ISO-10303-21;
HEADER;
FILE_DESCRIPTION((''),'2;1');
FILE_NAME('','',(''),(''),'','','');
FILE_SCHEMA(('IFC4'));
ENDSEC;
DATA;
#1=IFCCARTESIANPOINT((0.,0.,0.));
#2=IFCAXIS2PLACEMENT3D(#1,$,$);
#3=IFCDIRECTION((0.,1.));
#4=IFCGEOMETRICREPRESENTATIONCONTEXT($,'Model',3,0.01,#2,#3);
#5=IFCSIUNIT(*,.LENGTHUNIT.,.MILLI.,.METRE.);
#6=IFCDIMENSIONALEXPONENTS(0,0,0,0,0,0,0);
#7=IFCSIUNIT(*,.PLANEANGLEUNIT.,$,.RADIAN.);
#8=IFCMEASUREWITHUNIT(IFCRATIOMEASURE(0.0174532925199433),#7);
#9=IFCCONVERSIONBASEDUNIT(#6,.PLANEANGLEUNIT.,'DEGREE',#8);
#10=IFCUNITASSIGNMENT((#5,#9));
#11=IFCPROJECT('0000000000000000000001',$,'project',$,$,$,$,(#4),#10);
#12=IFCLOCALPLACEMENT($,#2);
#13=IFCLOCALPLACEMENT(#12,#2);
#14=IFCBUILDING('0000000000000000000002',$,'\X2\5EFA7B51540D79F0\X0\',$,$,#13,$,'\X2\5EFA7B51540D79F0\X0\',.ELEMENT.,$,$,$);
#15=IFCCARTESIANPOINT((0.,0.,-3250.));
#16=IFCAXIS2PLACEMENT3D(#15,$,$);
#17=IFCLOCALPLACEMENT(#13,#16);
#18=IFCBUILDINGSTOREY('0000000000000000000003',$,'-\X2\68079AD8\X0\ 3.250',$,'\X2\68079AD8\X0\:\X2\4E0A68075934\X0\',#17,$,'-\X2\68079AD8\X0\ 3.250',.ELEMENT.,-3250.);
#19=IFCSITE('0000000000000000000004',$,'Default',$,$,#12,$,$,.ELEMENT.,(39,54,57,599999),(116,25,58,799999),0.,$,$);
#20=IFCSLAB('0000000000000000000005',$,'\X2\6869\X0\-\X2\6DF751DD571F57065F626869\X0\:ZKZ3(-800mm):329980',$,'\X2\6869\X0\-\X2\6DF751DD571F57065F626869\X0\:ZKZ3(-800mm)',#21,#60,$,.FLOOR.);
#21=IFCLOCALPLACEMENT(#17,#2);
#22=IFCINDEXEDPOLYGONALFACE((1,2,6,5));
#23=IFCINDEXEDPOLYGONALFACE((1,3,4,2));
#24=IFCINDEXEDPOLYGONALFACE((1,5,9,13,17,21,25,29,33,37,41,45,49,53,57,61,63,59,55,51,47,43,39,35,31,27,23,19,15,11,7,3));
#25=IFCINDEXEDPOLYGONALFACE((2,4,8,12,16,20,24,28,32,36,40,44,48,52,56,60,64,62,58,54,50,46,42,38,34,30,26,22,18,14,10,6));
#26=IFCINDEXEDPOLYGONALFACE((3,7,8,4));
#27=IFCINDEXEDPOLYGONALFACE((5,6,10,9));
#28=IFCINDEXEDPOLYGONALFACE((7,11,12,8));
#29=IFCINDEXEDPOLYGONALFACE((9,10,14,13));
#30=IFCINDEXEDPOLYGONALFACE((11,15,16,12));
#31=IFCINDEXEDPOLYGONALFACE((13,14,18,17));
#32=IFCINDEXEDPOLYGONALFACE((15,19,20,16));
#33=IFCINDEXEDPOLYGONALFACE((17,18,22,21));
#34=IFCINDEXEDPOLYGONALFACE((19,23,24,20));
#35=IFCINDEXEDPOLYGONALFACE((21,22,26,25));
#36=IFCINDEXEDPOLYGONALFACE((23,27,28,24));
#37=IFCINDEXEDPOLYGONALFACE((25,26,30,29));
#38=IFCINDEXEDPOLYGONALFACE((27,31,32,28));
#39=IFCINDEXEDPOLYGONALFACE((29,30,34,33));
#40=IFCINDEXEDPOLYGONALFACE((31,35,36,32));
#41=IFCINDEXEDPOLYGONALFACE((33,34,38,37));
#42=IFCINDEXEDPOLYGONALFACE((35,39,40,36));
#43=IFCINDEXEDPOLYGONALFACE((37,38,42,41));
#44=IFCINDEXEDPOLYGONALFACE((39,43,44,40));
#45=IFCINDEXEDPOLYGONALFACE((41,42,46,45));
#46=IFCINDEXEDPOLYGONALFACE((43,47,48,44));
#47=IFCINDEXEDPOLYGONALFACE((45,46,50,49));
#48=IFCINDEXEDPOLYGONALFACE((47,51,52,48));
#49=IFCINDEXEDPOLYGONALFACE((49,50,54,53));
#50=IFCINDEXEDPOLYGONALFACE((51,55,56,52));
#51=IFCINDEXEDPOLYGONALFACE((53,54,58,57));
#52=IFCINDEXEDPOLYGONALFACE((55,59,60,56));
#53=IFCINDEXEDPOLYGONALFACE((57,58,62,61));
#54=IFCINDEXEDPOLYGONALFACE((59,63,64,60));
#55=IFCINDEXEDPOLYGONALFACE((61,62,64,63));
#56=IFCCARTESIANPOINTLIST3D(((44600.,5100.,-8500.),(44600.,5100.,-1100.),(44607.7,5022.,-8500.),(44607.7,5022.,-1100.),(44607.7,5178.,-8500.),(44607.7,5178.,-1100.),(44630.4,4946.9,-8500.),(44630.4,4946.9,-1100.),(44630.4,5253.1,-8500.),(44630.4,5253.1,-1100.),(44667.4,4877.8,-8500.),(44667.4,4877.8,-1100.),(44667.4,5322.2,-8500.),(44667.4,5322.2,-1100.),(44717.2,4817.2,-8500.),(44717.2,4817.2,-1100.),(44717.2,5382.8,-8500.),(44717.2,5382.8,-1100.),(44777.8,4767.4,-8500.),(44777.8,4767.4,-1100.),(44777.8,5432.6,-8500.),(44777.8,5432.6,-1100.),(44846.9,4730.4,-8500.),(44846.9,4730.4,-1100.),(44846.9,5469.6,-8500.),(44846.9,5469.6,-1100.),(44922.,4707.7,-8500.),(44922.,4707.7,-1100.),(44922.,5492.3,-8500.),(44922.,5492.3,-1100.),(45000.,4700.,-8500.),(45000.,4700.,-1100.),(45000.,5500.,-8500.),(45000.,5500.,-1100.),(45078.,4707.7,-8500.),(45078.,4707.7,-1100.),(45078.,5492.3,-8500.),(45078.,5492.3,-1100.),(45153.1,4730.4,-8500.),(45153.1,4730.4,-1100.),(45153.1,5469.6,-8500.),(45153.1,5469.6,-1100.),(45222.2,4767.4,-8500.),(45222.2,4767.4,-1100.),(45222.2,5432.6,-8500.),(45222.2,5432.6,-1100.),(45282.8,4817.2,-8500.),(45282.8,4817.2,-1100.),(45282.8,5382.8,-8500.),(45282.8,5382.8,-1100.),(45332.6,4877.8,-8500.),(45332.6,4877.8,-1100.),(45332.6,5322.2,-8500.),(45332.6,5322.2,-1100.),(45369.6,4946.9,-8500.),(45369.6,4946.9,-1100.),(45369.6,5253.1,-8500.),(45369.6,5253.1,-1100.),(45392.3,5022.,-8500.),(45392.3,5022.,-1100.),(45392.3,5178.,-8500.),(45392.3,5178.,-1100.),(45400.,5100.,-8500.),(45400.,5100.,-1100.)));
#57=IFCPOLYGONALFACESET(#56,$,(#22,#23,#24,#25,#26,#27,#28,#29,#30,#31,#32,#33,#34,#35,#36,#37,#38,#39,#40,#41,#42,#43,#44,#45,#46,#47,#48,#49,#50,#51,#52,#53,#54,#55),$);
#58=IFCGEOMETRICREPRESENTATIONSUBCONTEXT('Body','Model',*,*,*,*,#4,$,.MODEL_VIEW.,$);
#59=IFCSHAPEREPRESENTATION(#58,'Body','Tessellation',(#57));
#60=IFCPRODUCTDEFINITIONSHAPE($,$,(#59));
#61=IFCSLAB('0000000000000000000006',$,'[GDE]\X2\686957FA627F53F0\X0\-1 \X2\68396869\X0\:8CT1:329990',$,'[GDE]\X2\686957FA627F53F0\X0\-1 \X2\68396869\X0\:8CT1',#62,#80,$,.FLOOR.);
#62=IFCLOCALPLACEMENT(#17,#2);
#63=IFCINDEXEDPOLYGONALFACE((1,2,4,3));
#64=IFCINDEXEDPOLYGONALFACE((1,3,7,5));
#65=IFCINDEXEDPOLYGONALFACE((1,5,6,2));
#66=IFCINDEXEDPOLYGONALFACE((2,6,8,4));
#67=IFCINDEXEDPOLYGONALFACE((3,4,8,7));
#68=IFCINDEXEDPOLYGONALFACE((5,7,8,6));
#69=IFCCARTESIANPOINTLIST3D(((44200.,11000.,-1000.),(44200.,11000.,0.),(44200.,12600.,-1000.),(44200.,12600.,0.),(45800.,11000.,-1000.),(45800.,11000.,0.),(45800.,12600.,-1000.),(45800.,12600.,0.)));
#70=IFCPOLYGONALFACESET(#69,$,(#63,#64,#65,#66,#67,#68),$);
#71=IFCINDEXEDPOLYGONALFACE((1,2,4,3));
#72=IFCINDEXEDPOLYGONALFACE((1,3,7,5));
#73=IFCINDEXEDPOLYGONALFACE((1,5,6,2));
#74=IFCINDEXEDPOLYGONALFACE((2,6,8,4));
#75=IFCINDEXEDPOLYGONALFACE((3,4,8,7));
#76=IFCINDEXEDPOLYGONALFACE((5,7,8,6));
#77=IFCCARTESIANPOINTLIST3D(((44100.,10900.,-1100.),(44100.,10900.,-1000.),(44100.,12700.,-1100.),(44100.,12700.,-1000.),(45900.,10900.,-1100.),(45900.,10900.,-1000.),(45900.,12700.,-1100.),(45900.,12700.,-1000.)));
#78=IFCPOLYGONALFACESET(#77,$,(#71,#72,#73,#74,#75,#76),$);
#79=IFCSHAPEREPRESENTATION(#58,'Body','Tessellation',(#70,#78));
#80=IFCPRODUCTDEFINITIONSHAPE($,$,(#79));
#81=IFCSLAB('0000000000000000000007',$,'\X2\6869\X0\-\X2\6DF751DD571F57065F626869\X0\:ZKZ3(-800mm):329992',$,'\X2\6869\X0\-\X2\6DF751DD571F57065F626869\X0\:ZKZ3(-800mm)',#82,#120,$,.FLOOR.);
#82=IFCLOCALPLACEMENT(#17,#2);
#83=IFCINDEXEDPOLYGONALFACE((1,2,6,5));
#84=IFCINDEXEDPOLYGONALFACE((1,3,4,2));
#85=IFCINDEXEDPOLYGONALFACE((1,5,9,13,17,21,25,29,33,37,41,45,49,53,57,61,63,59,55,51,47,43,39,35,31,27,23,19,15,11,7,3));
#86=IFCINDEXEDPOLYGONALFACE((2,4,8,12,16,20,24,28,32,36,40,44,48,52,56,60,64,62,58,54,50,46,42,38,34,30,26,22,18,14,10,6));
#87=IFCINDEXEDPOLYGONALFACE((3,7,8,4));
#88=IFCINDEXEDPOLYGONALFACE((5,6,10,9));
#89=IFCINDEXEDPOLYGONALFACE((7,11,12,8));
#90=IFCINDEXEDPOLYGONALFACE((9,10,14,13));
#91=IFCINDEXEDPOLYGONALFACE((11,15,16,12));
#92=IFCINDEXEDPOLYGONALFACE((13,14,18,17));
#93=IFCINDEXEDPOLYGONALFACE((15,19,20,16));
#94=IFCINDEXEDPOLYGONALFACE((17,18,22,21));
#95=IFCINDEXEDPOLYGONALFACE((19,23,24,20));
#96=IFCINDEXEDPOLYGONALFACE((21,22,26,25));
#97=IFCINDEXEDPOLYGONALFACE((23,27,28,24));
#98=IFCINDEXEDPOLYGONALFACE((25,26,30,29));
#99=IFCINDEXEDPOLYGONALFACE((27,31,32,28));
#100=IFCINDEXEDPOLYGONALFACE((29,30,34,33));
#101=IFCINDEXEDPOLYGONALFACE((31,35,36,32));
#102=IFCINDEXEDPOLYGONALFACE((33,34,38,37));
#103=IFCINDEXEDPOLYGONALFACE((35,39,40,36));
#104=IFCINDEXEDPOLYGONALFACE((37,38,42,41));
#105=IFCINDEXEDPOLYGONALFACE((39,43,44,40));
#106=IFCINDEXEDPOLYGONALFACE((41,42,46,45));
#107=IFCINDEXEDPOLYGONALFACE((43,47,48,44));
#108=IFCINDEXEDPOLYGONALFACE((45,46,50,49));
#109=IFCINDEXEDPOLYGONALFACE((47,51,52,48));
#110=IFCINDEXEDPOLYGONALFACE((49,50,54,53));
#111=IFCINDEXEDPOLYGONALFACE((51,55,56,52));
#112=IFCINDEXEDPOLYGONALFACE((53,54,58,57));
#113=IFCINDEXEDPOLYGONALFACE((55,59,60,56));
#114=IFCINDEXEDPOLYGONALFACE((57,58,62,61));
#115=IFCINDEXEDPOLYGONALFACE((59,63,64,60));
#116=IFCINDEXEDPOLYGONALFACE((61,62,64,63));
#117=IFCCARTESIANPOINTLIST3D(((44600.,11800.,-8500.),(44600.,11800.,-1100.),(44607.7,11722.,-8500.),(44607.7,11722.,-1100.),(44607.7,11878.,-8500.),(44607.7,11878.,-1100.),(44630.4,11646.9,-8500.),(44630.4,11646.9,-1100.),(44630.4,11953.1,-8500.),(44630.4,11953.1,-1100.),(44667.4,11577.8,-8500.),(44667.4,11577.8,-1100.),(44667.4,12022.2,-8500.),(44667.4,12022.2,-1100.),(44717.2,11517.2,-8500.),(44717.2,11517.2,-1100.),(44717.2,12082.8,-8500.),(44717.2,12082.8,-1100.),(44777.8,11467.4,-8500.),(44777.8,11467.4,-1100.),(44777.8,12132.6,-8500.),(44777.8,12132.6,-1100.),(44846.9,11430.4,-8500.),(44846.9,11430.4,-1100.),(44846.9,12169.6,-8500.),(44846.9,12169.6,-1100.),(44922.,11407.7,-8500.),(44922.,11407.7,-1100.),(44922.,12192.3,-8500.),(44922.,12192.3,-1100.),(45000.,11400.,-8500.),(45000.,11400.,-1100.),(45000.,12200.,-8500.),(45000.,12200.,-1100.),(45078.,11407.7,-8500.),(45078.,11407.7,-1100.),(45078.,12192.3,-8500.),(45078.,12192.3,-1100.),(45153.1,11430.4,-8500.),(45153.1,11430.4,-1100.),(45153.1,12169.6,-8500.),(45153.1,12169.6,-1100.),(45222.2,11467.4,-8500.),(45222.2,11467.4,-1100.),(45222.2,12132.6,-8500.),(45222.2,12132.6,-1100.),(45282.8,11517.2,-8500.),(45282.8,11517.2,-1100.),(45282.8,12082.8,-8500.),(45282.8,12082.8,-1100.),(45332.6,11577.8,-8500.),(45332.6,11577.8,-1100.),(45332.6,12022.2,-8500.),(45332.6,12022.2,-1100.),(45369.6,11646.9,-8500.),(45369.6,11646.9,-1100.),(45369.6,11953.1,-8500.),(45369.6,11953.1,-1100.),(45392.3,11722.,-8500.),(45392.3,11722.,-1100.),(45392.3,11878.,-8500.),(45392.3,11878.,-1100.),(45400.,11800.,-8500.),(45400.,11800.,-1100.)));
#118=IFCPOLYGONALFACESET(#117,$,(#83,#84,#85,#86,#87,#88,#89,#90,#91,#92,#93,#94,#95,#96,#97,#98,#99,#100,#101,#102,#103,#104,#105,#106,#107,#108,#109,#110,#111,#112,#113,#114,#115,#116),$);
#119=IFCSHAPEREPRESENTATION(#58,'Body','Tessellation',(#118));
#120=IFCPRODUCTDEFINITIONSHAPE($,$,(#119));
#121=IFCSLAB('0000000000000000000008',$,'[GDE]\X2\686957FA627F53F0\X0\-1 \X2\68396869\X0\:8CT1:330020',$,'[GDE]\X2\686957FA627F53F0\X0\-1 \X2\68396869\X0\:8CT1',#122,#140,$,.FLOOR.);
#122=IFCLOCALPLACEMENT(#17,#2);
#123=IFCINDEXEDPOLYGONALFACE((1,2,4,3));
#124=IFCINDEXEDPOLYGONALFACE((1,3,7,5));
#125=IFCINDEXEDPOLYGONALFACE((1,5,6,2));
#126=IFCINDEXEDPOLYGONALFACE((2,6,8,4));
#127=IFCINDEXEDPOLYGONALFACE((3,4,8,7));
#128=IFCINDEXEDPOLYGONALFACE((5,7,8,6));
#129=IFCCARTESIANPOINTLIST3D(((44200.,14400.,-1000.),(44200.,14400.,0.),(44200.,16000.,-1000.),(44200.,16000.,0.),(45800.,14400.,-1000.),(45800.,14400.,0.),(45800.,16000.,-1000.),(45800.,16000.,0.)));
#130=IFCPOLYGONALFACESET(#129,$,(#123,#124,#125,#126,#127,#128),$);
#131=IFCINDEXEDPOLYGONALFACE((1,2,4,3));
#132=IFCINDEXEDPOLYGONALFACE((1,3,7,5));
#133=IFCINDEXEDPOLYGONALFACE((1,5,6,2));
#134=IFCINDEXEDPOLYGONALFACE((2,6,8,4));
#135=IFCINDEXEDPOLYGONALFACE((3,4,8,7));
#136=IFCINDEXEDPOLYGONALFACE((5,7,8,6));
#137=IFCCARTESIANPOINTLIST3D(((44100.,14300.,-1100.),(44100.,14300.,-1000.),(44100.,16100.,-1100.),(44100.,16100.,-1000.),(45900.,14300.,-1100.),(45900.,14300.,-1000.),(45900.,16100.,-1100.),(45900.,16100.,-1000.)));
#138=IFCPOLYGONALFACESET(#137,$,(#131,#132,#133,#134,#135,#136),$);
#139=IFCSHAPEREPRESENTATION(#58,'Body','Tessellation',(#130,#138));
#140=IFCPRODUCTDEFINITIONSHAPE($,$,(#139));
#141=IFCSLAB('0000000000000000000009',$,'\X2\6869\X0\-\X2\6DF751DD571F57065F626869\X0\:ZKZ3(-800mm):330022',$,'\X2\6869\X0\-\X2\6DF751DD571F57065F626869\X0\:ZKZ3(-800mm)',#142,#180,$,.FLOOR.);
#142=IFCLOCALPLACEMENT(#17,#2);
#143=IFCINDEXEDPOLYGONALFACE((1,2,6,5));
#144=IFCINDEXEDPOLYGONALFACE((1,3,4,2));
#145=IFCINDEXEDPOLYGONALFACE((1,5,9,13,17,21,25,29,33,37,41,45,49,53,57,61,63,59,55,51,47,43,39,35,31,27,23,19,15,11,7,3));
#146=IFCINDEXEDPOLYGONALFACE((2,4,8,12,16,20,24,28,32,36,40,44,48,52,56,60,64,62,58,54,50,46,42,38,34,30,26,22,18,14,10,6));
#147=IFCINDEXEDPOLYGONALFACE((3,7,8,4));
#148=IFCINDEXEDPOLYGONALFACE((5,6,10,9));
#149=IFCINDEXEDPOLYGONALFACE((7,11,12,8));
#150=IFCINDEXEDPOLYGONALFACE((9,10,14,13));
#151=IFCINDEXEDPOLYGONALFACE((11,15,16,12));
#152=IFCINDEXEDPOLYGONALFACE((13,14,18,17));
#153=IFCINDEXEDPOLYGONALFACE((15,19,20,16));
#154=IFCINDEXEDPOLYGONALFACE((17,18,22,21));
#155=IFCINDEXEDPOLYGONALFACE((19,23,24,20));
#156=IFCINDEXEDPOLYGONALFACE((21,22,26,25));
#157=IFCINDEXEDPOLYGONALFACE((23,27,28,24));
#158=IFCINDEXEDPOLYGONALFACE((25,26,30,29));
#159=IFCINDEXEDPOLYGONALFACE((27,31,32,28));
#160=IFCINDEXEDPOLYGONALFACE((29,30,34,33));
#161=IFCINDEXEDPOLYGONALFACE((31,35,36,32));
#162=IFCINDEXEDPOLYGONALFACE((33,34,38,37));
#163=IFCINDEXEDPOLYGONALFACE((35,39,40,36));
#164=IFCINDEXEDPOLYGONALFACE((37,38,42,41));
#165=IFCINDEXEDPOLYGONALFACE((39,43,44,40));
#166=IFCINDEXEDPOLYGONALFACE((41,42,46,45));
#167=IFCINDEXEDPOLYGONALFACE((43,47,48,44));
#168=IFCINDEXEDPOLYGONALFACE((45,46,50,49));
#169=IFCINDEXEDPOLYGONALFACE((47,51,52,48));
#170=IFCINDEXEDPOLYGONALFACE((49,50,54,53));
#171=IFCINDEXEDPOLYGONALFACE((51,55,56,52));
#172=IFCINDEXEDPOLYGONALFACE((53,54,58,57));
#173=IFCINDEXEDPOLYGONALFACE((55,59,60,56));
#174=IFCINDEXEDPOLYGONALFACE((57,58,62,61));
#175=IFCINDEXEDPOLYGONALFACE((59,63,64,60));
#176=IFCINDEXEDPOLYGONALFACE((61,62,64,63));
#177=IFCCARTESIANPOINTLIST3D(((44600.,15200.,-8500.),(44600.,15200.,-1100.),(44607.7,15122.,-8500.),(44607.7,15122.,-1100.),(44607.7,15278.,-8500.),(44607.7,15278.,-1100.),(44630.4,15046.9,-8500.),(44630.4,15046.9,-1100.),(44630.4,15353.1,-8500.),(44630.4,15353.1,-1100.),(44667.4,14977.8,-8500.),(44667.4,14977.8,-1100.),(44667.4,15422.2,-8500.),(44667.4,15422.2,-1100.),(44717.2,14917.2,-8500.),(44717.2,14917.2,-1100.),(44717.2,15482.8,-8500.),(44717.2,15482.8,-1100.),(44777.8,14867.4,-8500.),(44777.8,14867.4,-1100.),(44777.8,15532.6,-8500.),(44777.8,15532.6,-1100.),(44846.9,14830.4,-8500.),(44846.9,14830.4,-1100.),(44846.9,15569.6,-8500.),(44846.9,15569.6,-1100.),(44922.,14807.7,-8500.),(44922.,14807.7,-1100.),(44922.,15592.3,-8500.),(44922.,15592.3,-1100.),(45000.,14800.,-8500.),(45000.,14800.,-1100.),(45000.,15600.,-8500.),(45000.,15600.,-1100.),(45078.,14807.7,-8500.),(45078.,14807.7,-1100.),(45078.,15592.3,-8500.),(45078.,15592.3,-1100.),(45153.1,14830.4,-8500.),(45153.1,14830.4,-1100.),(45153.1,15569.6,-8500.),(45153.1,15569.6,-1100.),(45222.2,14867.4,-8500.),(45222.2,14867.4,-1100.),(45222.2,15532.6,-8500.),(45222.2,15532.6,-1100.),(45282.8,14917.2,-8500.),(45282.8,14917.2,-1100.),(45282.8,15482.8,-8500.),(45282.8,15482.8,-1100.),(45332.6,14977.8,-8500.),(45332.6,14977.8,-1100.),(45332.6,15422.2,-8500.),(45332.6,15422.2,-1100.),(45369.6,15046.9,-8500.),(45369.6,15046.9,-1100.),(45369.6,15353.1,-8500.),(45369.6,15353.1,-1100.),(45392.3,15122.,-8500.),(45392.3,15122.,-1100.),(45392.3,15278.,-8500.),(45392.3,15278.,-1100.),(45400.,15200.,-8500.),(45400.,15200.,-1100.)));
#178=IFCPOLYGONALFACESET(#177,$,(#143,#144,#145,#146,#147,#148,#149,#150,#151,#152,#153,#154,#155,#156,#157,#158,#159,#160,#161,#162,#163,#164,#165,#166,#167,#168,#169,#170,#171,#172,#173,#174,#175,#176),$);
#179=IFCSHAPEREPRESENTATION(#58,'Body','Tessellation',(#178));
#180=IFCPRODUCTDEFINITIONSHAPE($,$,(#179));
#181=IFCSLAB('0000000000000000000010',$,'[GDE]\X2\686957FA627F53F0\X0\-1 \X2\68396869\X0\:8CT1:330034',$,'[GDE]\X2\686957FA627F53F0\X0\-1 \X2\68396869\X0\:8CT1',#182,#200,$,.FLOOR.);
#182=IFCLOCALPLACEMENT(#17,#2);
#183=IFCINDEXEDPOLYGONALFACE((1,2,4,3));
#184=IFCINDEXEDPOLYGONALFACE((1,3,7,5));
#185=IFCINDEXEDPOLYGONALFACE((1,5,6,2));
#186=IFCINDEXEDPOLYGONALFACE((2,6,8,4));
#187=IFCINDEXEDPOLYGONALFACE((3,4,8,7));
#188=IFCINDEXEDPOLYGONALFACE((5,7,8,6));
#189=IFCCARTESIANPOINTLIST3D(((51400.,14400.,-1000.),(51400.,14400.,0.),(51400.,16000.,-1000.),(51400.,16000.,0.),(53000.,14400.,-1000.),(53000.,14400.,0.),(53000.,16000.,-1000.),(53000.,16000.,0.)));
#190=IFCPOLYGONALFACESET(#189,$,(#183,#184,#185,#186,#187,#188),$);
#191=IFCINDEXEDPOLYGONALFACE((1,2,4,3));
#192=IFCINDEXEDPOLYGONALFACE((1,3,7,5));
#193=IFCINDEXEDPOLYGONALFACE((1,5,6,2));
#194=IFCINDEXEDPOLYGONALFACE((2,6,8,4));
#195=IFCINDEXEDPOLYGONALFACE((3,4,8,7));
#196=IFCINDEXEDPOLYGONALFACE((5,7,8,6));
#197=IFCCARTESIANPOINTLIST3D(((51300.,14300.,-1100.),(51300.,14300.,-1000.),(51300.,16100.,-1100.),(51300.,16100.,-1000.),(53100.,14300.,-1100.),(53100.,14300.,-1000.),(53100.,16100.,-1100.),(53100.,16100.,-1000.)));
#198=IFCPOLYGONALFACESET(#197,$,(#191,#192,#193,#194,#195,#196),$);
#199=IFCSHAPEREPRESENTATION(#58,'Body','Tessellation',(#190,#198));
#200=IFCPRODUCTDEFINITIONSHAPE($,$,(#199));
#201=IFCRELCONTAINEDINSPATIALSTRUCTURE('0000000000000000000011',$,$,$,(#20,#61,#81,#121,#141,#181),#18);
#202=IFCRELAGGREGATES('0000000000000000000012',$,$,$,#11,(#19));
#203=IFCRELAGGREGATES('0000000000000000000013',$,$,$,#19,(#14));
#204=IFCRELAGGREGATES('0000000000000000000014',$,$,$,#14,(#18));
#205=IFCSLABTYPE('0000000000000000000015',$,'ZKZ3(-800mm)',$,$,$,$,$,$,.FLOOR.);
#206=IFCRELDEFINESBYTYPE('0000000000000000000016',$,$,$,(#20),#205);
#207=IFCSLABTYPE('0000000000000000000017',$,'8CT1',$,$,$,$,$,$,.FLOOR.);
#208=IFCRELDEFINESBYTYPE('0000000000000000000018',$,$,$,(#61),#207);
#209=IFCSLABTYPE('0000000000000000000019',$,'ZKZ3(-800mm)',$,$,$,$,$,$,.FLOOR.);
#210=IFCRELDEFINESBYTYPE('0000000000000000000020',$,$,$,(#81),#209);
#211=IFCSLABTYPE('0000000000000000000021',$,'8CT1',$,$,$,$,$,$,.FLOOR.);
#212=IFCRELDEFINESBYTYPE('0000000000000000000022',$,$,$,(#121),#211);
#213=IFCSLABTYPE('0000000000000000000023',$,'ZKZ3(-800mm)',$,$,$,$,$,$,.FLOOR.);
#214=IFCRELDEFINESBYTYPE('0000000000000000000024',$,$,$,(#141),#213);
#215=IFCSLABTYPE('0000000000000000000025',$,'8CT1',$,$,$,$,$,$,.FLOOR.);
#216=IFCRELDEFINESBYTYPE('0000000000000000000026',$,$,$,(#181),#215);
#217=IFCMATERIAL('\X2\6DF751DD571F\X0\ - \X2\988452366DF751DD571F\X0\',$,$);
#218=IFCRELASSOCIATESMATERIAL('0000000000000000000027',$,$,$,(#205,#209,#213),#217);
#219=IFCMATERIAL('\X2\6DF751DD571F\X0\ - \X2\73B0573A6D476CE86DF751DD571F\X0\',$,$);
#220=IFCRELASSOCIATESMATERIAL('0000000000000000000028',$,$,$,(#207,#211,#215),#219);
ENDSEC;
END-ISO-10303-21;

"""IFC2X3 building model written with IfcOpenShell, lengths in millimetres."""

from ifc_helpers import new_model, entity, si_unit, converted_unit, direction, frame, frame_2d, origin, origin_2d_with_axis, place, context, subcontext, project, spatial, rectangle, circle, extrude, material, type_object, element, save


model = new_model("IFC2X3")

# Units and contexts
model_context = context("Model", 3, precision=0.01, world=origin(), true_north=direction((0.0, 1.0)))
body_context = subcontext(model_context, "Body", "Model", "MODEL_VIEW")
ifc_project = project(units=[si_unit("LENGTHUNIT", "METRE", prefix="MILLI"), converted_unit("PLANEANGLEUNIT", "DEGREE", entity("IfcRatioMeasure", 0.0174532925199433), si_unit("PLANEANGLEUNIT", "RADIAN"), dimensions=[0, 0, 0, 0, 0, 0, 0])], contexts=[model_context])

# Site, building, storey
site_placement = place(None, origin())
site = spatial("IfcSite", under=ifc_project, at=site_placement, Name="Default", CompositionType="ELEMENT", RefLatitude=(39, 54, 57, 599999), RefLongitude=(116, 25, 58, 799999), RefElevation=0.0)
building_placement = place(site_placement, origin())
building = spatial("IfcBuilding", under=site, at=building_placement, Name="建筑名称", LongName="建筑名称", CompositionType="ELEMENT")
storey_placement = place(building_placement, frame((0.0, 0.0, -3250.0)))
storey = spatial("IfcBuildingStorey", under=building, at=storey_placement, Name="-标高 3.250", ObjectType="标高:上标头", LongName="-标高 3.250", CompositionType="ELEMENT", Elevation=-3250.0)

# Slabs
ifc_material_1 = material(Name="混凝土 - 现场浇注混凝土")
ifc_material_2 = material(Name="混凝土 - 预制混凝土")
slab_type_1 = type_object("IfcSlabType", Name="ZKZ3(-800mm)", PredefinedType="FLOOR", material=ifc_material_2)
slab_1_placement = place(storey_placement, origin())
element("IfcSlab", 1, at=slab_1_placement, inside=storey, type_object=slab_type_1, Name="桩-混凝土圆形桩:ZKZ3(-800mm):329980", ObjectType="桩-混凝土圆形桩:ZKZ3(-800mm)", PredefinedType="FLOOR", context=body_context, shape_type="SweptSolid", body=[
    extrude(circle(Radius=400.0, at=origin_2d_with_axis()), frame((45000.0, 5100.0, -8500.0)), (0.0, 0.0, 1.0), 7400.0),
])
slab_type_2 = type_object("IfcSlabType", Name="8CT1", PredefinedType="FLOOR", material=ifc_material_1)
slab_2_placement = place(storey_placement, origin())
element("IfcSlab", 2, at=slab_2_placement, inside=storey, type_object=slab_type_2, Name="[GDE]桩基承台-1 根桩:8CT1:329990", ObjectType="[GDE]桩基承台-1 根桩:8CT1", PredefinedType="FLOOR", context=body_context, shape_type="SweptSolid", body=[
    extrude(rectangle(XDim=1600.0, YDim=1600.0, at=origin_2d_with_axis()), frame((45000.0, 11800.0, -1000.0), z_axis=(0.0, 0.0, 1.0), x_axis=(-1.0, 0.0, 0.0)), (0.0, 0.0, 1.0), 1000.0),
    extrude(rectangle(XDim=1800.0, YDim=1800.0, at=frame_2d((0.0, 0.0), x_axis=(1.0, 0.0))), frame((45000.0, 11800.0, -1100.0), z_axis=(0.0, 0.0, 1.0), x_axis=(-1.0, 0.0, 0.0)), (0.0, 0.0, 1.0), 100.0),
])
slab_type_3 = type_object("IfcSlabType", Name="ZKZ3(-800mm)", PredefinedType="FLOOR", material=ifc_material_2)
slab_3_placement = place(storey_placement, origin())
element("IfcSlab", 3, at=slab_3_placement, inside=storey, type_object=slab_type_3, Name="桩-混凝土圆形桩:ZKZ3(-800mm):329992", ObjectType="桩-混凝土圆形桩:ZKZ3(-800mm)", PredefinedType="FLOOR", context=body_context, shape_type="SweptSolid", body=[
    extrude(circle(Radius=400.0, at=frame_2d((0.0, 0.0), x_axis=(1.0, 0.0))), frame((45000.0, 11800.0, -8500.0)), (0.0, 0.0, 1.0), 7400.0),
])
slab_type_4 = type_object("IfcSlabType", Name="8CT1", PredefinedType="FLOOR", material=ifc_material_1)
slab_4_placement = place(storey_placement, origin())
element("IfcSlab", 4, at=slab_4_placement, inside=storey, type_object=slab_type_4, Name="[GDE]桩基承台-1 根桩:8CT1:330020", ObjectType="[GDE]桩基承台-1 根桩:8CT1", PredefinedType="FLOOR", context=body_context, shape_type="SweptSolid", body=[
    extrude(rectangle(XDim=1600.0, YDim=1600.0, at=origin_2d_with_axis()), frame((45000.0, 15200.0, -1000.0), z_axis=(0.0, 0.0, 1.0), x_axis=(-1.0, 0.0, 0.0)), (0.0, 0.0, 1.0), 1000.0),
    extrude(rectangle(XDim=1800.0, YDim=1800.0, at=frame_2d((0.0, 0.0), x_axis=(1.0, 0.0))), frame((45000.0, 15200.0, -1100.0), z_axis=(0.0, 0.0, 1.0), x_axis=(-1.0, 0.0, 0.0)), (0.0, 0.0, 1.0), 100.0),
])
slab_type_5 = type_object("IfcSlabType", Name="ZKZ3(-800mm)", PredefinedType="FLOOR", material=ifc_material_2)
slab_5_placement = place(storey_placement, origin())
element("IfcSlab", 5, at=slab_5_placement, inside=storey, type_object=slab_type_5, Name="桩-混凝土圆形桩:ZKZ3(-800mm):330022", ObjectType="桩-混凝土圆形桩:ZKZ3(-800mm)", PredefinedType="FLOOR", context=body_context, shape_type="SweptSolid", body=[
    extrude(circle(Radius=400.0, at=origin_2d_with_axis()), frame((45000.0, 15200.0, -8500.0)), (0.0, 0.0, 1.0), 7400.0),
])
slab_type_6 = type_object("IfcSlabType", Name="8CT1", PredefinedType="FLOOR", material=ifc_material_1)
slab_6_placement = place(storey_placement, origin())
element("IfcSlab", 6, at=slab_6_placement, inside=storey, type_object=slab_type_6, Name="[GDE]桩基承台-1 根桩:8CT1:330034", ObjectType="[GDE]桩基承台-1 根桩:8CT1", PredefinedType="FLOOR", context=body_context, shape_type="SweptSolid", body=[
    extrude(rectangle(XDim=1600.0, YDim=1600.0, at=origin_2d_with_axis()), frame((52200.0, 15200.0, -1000.0), z_axis=(0.0, 0.0, 1.0), x_axis=(-1.0, 0.0, 0.0)), (0.0, 0.0, 1.0), 1000.0),
    extrude(rectangle(XDim=1800.0, YDim=1800.0, at=frame_2d((0.0, 0.0), x_axis=(1.0, 0.0))), frame((52200.0, 15200.0, -1100.0), z_axis=(0.0, 0.0, 1.0), x_axis=(-1.0, 0.0, 0.0)), (0.0, 0.0, 1.0), 100.0),
])

save(model, "model.ifc")
